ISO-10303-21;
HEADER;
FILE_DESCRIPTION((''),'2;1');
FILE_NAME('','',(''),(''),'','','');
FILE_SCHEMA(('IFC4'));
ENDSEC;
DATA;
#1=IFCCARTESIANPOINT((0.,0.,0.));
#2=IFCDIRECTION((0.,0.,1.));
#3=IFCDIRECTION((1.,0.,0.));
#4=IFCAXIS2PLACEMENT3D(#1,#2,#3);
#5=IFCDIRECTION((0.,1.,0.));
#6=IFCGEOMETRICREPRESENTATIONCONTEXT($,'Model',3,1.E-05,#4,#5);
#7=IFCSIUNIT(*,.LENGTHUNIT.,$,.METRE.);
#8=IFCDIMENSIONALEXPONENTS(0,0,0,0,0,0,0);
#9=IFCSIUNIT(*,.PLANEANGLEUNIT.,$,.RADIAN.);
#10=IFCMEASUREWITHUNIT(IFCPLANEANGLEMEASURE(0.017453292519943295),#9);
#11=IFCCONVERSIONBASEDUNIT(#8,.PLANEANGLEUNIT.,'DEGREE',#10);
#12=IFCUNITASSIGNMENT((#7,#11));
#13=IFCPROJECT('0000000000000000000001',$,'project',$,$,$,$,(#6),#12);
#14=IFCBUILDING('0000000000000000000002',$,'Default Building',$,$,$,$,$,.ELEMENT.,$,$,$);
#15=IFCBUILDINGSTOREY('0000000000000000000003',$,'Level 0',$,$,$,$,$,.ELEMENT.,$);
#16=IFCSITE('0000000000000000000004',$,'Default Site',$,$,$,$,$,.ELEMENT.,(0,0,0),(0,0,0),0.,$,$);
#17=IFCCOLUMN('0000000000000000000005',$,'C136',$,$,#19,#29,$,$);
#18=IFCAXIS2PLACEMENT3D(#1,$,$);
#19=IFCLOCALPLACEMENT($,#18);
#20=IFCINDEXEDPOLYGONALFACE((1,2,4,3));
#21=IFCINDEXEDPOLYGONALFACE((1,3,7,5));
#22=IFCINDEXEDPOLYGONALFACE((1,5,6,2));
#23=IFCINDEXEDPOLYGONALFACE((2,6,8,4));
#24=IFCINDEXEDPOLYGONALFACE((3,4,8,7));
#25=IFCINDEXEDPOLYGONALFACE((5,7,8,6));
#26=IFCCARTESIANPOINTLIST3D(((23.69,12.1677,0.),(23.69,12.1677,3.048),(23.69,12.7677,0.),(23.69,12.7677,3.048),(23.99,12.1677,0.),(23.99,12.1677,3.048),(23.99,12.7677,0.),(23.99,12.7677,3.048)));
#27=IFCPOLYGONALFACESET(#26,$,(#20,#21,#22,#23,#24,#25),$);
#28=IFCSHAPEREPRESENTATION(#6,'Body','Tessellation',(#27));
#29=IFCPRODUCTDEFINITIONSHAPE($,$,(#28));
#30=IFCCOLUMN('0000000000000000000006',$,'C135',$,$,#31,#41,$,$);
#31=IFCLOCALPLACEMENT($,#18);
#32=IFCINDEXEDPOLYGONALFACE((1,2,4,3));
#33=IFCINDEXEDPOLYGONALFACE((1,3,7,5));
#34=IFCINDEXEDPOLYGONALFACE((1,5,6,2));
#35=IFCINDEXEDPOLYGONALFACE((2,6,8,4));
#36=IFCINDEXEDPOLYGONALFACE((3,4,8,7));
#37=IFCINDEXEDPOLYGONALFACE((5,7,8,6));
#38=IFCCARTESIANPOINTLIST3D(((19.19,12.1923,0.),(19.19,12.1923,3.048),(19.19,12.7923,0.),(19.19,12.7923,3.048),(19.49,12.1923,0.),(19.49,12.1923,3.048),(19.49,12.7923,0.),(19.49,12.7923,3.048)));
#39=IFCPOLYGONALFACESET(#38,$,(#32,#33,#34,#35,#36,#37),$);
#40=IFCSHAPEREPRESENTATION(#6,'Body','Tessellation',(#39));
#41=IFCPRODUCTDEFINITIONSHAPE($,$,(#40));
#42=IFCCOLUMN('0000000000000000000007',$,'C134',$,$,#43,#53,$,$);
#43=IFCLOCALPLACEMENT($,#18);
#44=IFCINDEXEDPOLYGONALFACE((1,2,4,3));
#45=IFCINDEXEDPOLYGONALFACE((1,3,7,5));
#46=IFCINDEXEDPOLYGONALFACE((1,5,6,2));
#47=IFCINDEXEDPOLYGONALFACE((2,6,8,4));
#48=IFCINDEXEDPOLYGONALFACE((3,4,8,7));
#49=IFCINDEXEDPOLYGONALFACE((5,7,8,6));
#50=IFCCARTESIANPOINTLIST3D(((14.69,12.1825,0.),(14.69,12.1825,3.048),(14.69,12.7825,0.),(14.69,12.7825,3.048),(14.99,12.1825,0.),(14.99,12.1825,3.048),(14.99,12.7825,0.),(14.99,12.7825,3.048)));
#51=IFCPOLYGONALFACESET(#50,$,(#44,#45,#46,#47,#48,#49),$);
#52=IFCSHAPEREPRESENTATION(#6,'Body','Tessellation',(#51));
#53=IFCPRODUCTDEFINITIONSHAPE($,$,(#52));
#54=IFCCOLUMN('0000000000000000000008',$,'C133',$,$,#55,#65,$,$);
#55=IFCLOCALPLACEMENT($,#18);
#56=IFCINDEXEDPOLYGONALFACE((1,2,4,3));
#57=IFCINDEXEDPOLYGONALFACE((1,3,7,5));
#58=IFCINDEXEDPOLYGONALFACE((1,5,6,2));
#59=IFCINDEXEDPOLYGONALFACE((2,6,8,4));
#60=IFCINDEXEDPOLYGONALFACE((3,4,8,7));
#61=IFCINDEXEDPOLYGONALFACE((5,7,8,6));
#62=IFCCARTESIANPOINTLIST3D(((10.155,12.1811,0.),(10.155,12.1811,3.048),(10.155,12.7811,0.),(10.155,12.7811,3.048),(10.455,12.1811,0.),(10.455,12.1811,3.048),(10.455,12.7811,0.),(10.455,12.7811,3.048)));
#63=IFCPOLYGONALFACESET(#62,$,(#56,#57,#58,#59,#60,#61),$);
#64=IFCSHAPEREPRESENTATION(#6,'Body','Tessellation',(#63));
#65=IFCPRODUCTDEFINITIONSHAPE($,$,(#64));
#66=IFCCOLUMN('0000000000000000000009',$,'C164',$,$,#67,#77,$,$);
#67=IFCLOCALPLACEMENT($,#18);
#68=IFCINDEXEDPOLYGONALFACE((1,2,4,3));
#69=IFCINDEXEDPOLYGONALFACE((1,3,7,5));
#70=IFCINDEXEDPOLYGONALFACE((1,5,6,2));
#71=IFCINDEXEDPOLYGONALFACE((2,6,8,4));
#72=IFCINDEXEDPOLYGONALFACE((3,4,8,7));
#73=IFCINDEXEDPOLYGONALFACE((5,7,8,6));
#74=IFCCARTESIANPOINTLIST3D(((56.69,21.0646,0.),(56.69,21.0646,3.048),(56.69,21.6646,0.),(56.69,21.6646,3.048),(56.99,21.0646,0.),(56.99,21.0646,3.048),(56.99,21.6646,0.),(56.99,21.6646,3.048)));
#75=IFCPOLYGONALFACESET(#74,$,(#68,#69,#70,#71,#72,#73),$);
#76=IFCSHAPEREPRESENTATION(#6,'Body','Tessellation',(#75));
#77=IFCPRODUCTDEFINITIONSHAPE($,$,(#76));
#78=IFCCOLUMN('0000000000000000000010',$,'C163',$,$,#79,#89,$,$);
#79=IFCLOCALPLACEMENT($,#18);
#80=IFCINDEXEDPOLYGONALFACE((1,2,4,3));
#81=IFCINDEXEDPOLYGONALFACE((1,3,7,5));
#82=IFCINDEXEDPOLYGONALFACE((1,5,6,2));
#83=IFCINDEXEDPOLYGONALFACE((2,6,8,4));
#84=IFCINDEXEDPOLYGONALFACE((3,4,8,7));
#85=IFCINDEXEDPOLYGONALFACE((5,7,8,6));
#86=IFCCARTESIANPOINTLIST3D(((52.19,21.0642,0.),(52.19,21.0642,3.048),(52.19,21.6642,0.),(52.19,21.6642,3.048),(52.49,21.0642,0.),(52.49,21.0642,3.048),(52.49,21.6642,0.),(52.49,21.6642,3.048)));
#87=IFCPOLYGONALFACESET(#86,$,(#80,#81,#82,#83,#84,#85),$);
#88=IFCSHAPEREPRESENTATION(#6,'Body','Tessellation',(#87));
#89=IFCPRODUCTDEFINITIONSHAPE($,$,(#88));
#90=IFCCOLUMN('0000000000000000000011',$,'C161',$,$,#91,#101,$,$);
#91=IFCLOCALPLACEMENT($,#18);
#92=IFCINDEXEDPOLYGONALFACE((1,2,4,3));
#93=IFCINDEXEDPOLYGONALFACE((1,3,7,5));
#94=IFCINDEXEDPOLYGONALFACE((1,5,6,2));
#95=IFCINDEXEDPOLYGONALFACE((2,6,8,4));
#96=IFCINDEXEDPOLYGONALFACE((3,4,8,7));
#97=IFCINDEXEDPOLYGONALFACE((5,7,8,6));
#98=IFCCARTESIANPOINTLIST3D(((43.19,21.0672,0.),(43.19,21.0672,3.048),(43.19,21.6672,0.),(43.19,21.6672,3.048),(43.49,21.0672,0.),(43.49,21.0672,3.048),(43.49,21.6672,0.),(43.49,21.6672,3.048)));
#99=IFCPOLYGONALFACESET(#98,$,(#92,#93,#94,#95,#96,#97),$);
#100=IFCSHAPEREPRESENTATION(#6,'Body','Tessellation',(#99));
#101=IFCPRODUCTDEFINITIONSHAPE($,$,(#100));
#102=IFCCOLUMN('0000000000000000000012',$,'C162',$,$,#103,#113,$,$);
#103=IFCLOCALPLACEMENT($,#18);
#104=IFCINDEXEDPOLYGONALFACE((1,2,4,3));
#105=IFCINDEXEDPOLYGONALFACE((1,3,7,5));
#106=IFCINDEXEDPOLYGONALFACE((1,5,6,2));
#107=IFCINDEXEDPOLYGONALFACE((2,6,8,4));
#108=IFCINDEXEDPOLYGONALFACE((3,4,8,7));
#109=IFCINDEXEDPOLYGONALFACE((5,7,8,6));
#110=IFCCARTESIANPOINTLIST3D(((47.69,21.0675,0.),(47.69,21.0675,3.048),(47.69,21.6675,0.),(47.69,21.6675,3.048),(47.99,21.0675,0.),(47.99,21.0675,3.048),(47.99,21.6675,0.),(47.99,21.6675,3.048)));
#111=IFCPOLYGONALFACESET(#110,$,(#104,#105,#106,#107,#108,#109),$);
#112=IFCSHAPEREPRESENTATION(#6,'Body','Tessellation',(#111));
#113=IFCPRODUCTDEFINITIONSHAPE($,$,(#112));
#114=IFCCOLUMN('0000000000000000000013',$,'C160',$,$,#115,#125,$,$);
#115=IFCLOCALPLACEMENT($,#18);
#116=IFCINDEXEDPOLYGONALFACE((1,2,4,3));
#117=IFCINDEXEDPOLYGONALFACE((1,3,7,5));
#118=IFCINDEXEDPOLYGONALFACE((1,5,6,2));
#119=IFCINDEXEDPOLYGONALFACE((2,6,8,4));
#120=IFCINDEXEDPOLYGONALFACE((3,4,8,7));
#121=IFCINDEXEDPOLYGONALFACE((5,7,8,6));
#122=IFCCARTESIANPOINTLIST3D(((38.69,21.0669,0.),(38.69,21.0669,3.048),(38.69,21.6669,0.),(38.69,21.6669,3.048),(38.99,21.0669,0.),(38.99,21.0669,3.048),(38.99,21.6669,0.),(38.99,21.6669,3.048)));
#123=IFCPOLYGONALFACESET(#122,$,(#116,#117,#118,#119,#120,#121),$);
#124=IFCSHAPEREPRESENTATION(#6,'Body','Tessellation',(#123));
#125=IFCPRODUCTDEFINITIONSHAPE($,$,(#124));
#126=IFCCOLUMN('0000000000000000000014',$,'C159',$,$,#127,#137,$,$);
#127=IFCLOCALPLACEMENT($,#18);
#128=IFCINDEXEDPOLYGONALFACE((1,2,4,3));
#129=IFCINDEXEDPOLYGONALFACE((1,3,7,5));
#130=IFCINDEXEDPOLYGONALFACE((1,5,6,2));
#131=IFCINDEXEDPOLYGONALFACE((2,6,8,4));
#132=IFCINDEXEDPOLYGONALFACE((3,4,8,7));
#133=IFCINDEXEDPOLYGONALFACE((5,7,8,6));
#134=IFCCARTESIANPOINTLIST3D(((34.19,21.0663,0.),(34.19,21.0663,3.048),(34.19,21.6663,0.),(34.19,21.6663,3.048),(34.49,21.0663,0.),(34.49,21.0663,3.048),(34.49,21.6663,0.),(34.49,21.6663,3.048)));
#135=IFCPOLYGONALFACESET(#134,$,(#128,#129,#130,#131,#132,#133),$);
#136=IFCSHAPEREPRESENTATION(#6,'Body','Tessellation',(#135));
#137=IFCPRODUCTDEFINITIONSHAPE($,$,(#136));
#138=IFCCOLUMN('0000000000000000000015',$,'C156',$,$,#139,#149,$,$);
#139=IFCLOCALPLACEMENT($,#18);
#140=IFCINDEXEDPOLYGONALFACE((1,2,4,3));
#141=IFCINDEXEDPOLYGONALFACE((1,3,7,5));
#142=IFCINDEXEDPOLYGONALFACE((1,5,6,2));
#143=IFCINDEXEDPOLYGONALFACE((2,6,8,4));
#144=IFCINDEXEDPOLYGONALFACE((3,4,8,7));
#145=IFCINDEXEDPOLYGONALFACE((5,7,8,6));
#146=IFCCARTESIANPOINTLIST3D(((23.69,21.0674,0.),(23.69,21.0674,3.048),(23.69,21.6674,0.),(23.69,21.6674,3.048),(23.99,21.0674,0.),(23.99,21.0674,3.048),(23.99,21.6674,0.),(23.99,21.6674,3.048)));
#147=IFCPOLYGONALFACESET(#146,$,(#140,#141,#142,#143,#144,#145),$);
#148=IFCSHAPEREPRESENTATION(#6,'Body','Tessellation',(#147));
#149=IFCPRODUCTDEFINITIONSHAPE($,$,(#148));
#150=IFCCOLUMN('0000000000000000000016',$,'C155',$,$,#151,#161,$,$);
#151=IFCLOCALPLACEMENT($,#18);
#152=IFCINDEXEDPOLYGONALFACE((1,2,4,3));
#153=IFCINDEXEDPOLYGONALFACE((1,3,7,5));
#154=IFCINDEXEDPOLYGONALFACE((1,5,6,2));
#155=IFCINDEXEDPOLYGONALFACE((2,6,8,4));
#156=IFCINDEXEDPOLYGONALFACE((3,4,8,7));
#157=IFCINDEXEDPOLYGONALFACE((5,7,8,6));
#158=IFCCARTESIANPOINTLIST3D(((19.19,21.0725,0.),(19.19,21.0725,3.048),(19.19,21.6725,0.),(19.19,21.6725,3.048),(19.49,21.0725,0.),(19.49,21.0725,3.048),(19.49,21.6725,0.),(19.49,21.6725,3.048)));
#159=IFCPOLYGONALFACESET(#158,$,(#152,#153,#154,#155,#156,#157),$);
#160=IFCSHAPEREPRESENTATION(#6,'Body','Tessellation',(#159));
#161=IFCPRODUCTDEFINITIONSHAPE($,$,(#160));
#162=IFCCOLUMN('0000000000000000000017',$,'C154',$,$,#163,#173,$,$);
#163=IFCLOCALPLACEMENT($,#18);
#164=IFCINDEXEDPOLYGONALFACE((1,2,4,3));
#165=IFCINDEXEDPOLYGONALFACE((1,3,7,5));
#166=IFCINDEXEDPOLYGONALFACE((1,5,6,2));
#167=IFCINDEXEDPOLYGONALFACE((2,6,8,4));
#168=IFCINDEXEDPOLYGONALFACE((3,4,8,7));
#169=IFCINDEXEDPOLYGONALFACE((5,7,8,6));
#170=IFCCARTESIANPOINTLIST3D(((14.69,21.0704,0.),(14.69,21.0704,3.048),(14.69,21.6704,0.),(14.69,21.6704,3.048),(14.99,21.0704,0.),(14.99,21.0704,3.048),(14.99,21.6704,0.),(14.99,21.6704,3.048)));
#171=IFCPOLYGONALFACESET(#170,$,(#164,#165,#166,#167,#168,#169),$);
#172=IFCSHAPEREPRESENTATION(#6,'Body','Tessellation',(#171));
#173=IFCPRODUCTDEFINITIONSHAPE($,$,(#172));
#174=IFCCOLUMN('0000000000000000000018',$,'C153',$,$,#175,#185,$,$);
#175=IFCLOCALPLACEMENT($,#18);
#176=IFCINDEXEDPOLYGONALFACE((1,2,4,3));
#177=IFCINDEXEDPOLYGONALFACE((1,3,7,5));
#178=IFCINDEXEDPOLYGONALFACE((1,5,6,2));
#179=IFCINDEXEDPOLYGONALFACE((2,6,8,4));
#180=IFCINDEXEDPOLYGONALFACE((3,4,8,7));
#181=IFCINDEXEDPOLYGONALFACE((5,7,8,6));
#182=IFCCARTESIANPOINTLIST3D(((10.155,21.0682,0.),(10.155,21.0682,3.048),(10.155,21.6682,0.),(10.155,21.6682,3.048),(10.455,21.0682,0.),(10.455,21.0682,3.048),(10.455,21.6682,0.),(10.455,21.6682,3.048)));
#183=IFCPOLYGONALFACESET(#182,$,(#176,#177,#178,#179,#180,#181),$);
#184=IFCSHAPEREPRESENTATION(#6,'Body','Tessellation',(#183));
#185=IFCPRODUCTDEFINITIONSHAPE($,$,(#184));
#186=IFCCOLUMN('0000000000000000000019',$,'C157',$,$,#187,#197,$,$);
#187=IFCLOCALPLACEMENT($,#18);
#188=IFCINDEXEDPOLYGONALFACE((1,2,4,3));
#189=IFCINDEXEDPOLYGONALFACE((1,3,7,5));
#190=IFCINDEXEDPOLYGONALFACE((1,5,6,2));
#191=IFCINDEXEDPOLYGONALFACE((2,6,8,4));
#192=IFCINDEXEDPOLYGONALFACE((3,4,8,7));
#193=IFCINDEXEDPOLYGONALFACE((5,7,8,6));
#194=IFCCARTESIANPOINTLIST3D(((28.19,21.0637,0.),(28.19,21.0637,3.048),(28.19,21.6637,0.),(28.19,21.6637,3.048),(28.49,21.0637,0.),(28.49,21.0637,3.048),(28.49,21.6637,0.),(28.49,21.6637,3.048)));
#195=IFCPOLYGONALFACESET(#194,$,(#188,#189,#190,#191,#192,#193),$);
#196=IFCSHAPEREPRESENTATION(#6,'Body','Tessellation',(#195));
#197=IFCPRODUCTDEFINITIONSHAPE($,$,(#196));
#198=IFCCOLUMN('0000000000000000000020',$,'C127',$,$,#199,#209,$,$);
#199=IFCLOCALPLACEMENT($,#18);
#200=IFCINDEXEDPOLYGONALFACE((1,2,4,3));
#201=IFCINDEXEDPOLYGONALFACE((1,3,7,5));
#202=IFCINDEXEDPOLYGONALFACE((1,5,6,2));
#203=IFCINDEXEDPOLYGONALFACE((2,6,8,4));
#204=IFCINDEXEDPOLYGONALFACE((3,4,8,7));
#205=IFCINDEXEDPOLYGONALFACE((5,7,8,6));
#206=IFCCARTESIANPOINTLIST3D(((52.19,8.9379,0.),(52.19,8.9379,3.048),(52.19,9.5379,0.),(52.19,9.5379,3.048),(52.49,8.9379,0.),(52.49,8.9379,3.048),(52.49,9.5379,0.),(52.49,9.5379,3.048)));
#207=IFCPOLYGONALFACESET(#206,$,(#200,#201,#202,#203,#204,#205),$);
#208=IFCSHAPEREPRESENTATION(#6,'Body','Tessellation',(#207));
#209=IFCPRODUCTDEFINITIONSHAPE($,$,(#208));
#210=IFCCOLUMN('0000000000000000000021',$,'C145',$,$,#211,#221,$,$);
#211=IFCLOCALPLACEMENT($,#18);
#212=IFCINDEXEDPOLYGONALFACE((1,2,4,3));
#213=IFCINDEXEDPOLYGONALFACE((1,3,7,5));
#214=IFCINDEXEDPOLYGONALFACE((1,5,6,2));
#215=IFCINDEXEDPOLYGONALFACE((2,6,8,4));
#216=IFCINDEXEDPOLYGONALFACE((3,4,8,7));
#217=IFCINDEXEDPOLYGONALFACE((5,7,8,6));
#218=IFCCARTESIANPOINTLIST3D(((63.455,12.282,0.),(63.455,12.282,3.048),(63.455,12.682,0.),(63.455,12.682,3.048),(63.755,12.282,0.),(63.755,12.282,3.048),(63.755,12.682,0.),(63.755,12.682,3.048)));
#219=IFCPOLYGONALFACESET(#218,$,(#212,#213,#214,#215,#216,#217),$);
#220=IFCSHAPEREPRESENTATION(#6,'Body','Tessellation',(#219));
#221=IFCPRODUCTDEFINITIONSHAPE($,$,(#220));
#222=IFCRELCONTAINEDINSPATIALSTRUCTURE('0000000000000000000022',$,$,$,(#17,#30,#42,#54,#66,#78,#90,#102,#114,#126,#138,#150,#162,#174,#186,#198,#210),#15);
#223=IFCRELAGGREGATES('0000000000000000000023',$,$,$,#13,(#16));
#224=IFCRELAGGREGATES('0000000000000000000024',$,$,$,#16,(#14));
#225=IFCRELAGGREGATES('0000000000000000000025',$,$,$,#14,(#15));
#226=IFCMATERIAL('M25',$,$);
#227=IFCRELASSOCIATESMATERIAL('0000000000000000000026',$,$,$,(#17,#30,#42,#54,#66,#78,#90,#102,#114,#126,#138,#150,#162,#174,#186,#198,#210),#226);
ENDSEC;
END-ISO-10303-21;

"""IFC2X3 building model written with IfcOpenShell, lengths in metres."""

from ifc_helpers import new_model, entity, si_unit, converted_unit, direction, frame, frame_2d, origin_with_axes, place, context, project, spatial, rectangle, extrude, material, element, save


model = new_model("IFC2X3")

# Units and contexts
model_context = context("Model", 3, precision=1e-05, world=origin_with_axes(), true_north=direction((0.0, 1.0, 0.0)))
ifc_project = project(units=[si_unit("LENGTHUNIT", "METRE"), converted_unit("PLANEANGLEUNIT", "DEGREE", entity("IfcPlaneAngleMeasure", 0.017453292519943295), si_unit("PLANEANGLEUNIT", "RADIAN"), dimensions=[0, 0, 0, 0, 0, 0, 0])], contexts=[model_context])

# Site, building, storey
site = spatial("IfcSite", under=ifc_project, Name="Default Site", CompositionType="ELEMENT", RefLatitude=(0, 0, 0), RefLongitude=(0, 0, 0), RefElevation=0.0)
building = spatial("IfcBuilding", under=site, Name="Default Building", CompositionType="ELEMENT")
storey = spatial("IfcBuildingStorey", under=building, Name="Level 0", CompositionType="ELEMENT")

# Columns
ifc_material = material(Name="M25")
placement = place(None, origin_with_axes())
element("IfcColumn", 1, at=placement, inside=storey, material=ifc_material, Name="C136", context=model_context, shape_type="SweptSolid", body=[
    extrude(rectangle(XDim=0.3, YDim=0.6, at=frame_2d((0.0, 0.0), x_axis=(1.0, 0.0, 0.0))), frame((23.84, 12.4677, 0.0), z_axis=(0.0, 0.0, 1.0), x_axis=(1.0, 0.0, 0.0)), (0.0, 0.0, 1.0), 3.048),
])
element("IfcColumn", 2, at=placement, inside=storey, material=ifc_material, Name="C135", context=model_context, shape_type="SweptSolid", body=[
    extrude(rectangle(XDim=0.3, YDim=0.6, at=frame_2d((0.0, 0.0), x_axis=(1.0, 0.0, 0.0))), frame((19.34, 12.4923, 0.0), z_axis=(0.0, 0.0, 1.0), x_axis=(1.0, 0.0, 0.0)), (0.0, 0.0, 1.0), 3.048),
])
element("IfcColumn", 3, at=placement, inside=storey, material=ifc_material, Name="C134", context=model_context, shape_type="SweptSolid", body=[
    extrude(rectangle(XDim=0.3, YDim=0.6, at=frame_2d((0.0, 0.0), x_axis=(1.0, 0.0, 0.0))), frame((14.84, 12.4825, 0.0), z_axis=(0.0, 0.0, 1.0), x_axis=(1.0, 0.0, 0.0)), (0.0, 0.0, 1.0), 3.048),
])
element("IfcColumn", 4, at=placement, inside=storey, material=ifc_material, Name="C133", context=model_context, shape_type="SweptSolid", body=[
    extrude(rectangle(XDim=0.3, YDim=0.6, at=frame_2d((0.0, 0.0), x_axis=(1.0, 0.0, 0.0))), frame((10.305, 12.4811, 0.0), z_axis=(0.0, 0.0, 1.0), x_axis=(1.0, 0.0, 0.0)), (0.0, 0.0, 1.0), 3.048),
])
element("IfcColumn", 5, at=placement, inside=storey, material=ifc_material, Name="C164", context=model_context, shape_type="SweptSolid", body=[
    extrude(rectangle(XDim=0.3, YDim=0.6, at=frame_2d((0.0, 0.0), x_axis=(1.0, 0.0, 0.0))), frame((56.84, 21.3646, 0.0), z_axis=(0.0, 0.0, 1.0), x_axis=(1.0, 0.0, 0.0)), (0.0, 0.0, 1.0), 3.048),
])
element("IfcColumn", 6, at=placement, inside=storey, material=ifc_material, Name="C163", context=model_context, shape_type="SweptSolid", body=[
    extrude(rectangle(XDim=0.3, YDim=0.6, at=frame_2d((0.0, 0.0), x_axis=(1.0, 0.0, 0.0))), frame((52.34, 21.3642, 0.0), z_axis=(0.0, 0.0, 1.0), x_axis=(1.0, 0.0, 0.0)), (0.0, 0.0, 1.0), 3.048),
])
element("IfcColumn", 7, at=placement, inside=storey, material=ifc_material, Name="C161", context=model_context, shape_type="SweptSolid", body=[
    extrude(rectangle(XDim=0.3, YDim=0.6, at=frame_2d((0.0, 0.0), x_axis=(1.0, 0.0, 0.0))), frame((43.34, 21.3672, 0.0), z_axis=(0.0, 0.0, 1.0), x_axis=(1.0, 0.0, 0.0)), (0.0, 0.0, 1.0), 3.048),
])
element("IfcColumn", 8, at=placement, inside=storey, material=ifc_material, Name="C162", context=model_context, shape_type="SweptSolid", body=[
    extrude(rectangle(XDim=0.3, YDim=0.6, at=frame_2d((0.0, 0.0), x_axis=(1.0, 0.0, 0.0))), frame((47.84, 21.3675, 0.0), z_axis=(0.0, 0.0, 1.0), x_axis=(1.0, 0.0, 0.0)), (0.0, 0.0, 1.0), 3.048),
])
element("IfcColumn", 9, at=placement, inside=storey, material=ifc_material, Name="C160", context=model_context, shape_type="SweptSolid", body=[
    extrude(rectangle(XDim=0.3, YDim=0.6, at=frame_2d((0.0, 0.0), x_axis=(1.0, 0.0, 0.0))), frame((38.84, 21.3669, 0.0), z_axis=(0.0, 0.0, 1.0), x_axis=(1.0, 0.0, 0.0)), (0.0, 0.0, 1.0), 3.048),
])
element("IfcColumn", 10, at=placement, inside=storey, material=ifc_material, Name="C159", context=model_context, shape_type="SweptSolid", body=[
    extrude(rectangle(XDim=0.3, YDim=0.6, at=frame_2d((0.0, 0.0), x_axis=(1.0, 0.0, 0.0))), frame((34.34, 21.3663, 0.0), z_axis=(0.0, 0.0, 1.0), x_axis=(1.0, 0.0, 0.0)), (0.0, 0.0, 1.0), 3.048),
])
element("IfcColumn", 11, at=placement, inside=storey, material=ifc_material, Name="C156", context=model_context, shape_type="SweptSolid", body=[
    extrude(rectangle(XDim=0.3, YDim=0.6, at=frame_2d((0.0, 0.0), x_axis=(1.0, 0.0, 0.0))), frame((23.84, 21.3674, 0.0), z_axis=(0.0, 0.0, 1.0), x_axis=(1.0, 0.0, 0.0)), (0.0, 0.0, 1.0), 3.048),
])
element("IfcColumn", 12, at=placement, inside=storey, material=ifc_material, Name="C155", context=model_context, shape_type="SweptSolid", body=[
    extrude(rectangle(XDim=0.3, YDim=0.6, at=frame_2d((0.0, 0.0), x_axis=(1.0, 0.0, 0.0))), frame((19.34, 21.3725, 0.0), z_axis=(0.0, 0.0, 1.0), x_axis=(1.0, 0.0, 0.0)), (0.0, 0.0, 1.0), 3.048),
])
element("IfcColumn", 13, at=placement, inside=storey, material=ifc_material, Name="C154", context=model_context, shape_type="SweptSolid", body=[
    extrude(rectangle(XDim=0.3, YDim=0.6, at=frame_2d((0.0, 0.0), x_axis=(1.0, 0.0, 0.0))), frame((14.84, 21.3704, 0.0), z_axis=(0.0, 0.0, 1.0), x_axis=(1.0, 0.0, 0.0)), (0.0, 0.0, 1.0), 3.048),
])
element("IfcColumn", 14, at=placement, inside=storey, material=ifc_material, Name="C153", context=model_context, shape_type="SweptSolid", body=[
    extrude(rectangle(XDim=0.3, YDim=0.6, at=frame_2d((0.0, 0.0), x_axis=(1.0, 0.0, 0.0))), frame((10.305, 21.3682, 0.0), z_axis=(0.0, 0.0, 1.0), x_axis=(1.0, 0.0, 0.0)), (0.0, 0.0, 1.0), 3.048),
])
element("IfcColumn", 15, at=placement, inside=storey, material=ifc_material, Name="C157", context=model_context, shape_type="SweptSolid", body=[
    extrude(rectangle(XDim=0.3, YDim=0.6, at=frame_2d((0.0, 0.0), x_axis=(1.0, 0.0, 0.0))), frame((28.34, 21.3637, 0.0), z_axis=(0.0, 0.0, 1.0), x_axis=(1.0, 0.0, 0.0)), (0.0, 0.0, 1.0), 3.048),
])
element("IfcColumn", 16, at=placement, inside=storey, material=ifc_material, Name="C127", context=model_context, shape_type="SweptSolid", body=[
    extrude(rectangle(XDim=0.3, YDim=0.6, at=frame_2d((0.0, 0.0), x_axis=(1.0, 0.0, 0.0))), frame((52.34, 9.2379, 0.0), z_axis=(0.0, 0.0, 1.0), x_axis=(1.0, 0.0, 0.0)), (0.0, 0.0, 1.0), 3.048),
])
element("IfcColumn", 17, at=placement, inside=storey, material=ifc_material, Name="C145", context=model_context, shape_type="SweptSolid", body=[
    extrude(rectangle(XDim=0.3, YDim=0.4, at=frame_2d((0.0, 0.0), x_axis=(1.0, 0.0, 0.0))), frame((63.605, 12.482, 0.0), z_axis=(0.0, 0.0, 1.0), x_axis=(1.0, 0.0, 0.0)), (0.0, 0.0, 1.0), 3.048),
])

save(model, "model.ifc")
